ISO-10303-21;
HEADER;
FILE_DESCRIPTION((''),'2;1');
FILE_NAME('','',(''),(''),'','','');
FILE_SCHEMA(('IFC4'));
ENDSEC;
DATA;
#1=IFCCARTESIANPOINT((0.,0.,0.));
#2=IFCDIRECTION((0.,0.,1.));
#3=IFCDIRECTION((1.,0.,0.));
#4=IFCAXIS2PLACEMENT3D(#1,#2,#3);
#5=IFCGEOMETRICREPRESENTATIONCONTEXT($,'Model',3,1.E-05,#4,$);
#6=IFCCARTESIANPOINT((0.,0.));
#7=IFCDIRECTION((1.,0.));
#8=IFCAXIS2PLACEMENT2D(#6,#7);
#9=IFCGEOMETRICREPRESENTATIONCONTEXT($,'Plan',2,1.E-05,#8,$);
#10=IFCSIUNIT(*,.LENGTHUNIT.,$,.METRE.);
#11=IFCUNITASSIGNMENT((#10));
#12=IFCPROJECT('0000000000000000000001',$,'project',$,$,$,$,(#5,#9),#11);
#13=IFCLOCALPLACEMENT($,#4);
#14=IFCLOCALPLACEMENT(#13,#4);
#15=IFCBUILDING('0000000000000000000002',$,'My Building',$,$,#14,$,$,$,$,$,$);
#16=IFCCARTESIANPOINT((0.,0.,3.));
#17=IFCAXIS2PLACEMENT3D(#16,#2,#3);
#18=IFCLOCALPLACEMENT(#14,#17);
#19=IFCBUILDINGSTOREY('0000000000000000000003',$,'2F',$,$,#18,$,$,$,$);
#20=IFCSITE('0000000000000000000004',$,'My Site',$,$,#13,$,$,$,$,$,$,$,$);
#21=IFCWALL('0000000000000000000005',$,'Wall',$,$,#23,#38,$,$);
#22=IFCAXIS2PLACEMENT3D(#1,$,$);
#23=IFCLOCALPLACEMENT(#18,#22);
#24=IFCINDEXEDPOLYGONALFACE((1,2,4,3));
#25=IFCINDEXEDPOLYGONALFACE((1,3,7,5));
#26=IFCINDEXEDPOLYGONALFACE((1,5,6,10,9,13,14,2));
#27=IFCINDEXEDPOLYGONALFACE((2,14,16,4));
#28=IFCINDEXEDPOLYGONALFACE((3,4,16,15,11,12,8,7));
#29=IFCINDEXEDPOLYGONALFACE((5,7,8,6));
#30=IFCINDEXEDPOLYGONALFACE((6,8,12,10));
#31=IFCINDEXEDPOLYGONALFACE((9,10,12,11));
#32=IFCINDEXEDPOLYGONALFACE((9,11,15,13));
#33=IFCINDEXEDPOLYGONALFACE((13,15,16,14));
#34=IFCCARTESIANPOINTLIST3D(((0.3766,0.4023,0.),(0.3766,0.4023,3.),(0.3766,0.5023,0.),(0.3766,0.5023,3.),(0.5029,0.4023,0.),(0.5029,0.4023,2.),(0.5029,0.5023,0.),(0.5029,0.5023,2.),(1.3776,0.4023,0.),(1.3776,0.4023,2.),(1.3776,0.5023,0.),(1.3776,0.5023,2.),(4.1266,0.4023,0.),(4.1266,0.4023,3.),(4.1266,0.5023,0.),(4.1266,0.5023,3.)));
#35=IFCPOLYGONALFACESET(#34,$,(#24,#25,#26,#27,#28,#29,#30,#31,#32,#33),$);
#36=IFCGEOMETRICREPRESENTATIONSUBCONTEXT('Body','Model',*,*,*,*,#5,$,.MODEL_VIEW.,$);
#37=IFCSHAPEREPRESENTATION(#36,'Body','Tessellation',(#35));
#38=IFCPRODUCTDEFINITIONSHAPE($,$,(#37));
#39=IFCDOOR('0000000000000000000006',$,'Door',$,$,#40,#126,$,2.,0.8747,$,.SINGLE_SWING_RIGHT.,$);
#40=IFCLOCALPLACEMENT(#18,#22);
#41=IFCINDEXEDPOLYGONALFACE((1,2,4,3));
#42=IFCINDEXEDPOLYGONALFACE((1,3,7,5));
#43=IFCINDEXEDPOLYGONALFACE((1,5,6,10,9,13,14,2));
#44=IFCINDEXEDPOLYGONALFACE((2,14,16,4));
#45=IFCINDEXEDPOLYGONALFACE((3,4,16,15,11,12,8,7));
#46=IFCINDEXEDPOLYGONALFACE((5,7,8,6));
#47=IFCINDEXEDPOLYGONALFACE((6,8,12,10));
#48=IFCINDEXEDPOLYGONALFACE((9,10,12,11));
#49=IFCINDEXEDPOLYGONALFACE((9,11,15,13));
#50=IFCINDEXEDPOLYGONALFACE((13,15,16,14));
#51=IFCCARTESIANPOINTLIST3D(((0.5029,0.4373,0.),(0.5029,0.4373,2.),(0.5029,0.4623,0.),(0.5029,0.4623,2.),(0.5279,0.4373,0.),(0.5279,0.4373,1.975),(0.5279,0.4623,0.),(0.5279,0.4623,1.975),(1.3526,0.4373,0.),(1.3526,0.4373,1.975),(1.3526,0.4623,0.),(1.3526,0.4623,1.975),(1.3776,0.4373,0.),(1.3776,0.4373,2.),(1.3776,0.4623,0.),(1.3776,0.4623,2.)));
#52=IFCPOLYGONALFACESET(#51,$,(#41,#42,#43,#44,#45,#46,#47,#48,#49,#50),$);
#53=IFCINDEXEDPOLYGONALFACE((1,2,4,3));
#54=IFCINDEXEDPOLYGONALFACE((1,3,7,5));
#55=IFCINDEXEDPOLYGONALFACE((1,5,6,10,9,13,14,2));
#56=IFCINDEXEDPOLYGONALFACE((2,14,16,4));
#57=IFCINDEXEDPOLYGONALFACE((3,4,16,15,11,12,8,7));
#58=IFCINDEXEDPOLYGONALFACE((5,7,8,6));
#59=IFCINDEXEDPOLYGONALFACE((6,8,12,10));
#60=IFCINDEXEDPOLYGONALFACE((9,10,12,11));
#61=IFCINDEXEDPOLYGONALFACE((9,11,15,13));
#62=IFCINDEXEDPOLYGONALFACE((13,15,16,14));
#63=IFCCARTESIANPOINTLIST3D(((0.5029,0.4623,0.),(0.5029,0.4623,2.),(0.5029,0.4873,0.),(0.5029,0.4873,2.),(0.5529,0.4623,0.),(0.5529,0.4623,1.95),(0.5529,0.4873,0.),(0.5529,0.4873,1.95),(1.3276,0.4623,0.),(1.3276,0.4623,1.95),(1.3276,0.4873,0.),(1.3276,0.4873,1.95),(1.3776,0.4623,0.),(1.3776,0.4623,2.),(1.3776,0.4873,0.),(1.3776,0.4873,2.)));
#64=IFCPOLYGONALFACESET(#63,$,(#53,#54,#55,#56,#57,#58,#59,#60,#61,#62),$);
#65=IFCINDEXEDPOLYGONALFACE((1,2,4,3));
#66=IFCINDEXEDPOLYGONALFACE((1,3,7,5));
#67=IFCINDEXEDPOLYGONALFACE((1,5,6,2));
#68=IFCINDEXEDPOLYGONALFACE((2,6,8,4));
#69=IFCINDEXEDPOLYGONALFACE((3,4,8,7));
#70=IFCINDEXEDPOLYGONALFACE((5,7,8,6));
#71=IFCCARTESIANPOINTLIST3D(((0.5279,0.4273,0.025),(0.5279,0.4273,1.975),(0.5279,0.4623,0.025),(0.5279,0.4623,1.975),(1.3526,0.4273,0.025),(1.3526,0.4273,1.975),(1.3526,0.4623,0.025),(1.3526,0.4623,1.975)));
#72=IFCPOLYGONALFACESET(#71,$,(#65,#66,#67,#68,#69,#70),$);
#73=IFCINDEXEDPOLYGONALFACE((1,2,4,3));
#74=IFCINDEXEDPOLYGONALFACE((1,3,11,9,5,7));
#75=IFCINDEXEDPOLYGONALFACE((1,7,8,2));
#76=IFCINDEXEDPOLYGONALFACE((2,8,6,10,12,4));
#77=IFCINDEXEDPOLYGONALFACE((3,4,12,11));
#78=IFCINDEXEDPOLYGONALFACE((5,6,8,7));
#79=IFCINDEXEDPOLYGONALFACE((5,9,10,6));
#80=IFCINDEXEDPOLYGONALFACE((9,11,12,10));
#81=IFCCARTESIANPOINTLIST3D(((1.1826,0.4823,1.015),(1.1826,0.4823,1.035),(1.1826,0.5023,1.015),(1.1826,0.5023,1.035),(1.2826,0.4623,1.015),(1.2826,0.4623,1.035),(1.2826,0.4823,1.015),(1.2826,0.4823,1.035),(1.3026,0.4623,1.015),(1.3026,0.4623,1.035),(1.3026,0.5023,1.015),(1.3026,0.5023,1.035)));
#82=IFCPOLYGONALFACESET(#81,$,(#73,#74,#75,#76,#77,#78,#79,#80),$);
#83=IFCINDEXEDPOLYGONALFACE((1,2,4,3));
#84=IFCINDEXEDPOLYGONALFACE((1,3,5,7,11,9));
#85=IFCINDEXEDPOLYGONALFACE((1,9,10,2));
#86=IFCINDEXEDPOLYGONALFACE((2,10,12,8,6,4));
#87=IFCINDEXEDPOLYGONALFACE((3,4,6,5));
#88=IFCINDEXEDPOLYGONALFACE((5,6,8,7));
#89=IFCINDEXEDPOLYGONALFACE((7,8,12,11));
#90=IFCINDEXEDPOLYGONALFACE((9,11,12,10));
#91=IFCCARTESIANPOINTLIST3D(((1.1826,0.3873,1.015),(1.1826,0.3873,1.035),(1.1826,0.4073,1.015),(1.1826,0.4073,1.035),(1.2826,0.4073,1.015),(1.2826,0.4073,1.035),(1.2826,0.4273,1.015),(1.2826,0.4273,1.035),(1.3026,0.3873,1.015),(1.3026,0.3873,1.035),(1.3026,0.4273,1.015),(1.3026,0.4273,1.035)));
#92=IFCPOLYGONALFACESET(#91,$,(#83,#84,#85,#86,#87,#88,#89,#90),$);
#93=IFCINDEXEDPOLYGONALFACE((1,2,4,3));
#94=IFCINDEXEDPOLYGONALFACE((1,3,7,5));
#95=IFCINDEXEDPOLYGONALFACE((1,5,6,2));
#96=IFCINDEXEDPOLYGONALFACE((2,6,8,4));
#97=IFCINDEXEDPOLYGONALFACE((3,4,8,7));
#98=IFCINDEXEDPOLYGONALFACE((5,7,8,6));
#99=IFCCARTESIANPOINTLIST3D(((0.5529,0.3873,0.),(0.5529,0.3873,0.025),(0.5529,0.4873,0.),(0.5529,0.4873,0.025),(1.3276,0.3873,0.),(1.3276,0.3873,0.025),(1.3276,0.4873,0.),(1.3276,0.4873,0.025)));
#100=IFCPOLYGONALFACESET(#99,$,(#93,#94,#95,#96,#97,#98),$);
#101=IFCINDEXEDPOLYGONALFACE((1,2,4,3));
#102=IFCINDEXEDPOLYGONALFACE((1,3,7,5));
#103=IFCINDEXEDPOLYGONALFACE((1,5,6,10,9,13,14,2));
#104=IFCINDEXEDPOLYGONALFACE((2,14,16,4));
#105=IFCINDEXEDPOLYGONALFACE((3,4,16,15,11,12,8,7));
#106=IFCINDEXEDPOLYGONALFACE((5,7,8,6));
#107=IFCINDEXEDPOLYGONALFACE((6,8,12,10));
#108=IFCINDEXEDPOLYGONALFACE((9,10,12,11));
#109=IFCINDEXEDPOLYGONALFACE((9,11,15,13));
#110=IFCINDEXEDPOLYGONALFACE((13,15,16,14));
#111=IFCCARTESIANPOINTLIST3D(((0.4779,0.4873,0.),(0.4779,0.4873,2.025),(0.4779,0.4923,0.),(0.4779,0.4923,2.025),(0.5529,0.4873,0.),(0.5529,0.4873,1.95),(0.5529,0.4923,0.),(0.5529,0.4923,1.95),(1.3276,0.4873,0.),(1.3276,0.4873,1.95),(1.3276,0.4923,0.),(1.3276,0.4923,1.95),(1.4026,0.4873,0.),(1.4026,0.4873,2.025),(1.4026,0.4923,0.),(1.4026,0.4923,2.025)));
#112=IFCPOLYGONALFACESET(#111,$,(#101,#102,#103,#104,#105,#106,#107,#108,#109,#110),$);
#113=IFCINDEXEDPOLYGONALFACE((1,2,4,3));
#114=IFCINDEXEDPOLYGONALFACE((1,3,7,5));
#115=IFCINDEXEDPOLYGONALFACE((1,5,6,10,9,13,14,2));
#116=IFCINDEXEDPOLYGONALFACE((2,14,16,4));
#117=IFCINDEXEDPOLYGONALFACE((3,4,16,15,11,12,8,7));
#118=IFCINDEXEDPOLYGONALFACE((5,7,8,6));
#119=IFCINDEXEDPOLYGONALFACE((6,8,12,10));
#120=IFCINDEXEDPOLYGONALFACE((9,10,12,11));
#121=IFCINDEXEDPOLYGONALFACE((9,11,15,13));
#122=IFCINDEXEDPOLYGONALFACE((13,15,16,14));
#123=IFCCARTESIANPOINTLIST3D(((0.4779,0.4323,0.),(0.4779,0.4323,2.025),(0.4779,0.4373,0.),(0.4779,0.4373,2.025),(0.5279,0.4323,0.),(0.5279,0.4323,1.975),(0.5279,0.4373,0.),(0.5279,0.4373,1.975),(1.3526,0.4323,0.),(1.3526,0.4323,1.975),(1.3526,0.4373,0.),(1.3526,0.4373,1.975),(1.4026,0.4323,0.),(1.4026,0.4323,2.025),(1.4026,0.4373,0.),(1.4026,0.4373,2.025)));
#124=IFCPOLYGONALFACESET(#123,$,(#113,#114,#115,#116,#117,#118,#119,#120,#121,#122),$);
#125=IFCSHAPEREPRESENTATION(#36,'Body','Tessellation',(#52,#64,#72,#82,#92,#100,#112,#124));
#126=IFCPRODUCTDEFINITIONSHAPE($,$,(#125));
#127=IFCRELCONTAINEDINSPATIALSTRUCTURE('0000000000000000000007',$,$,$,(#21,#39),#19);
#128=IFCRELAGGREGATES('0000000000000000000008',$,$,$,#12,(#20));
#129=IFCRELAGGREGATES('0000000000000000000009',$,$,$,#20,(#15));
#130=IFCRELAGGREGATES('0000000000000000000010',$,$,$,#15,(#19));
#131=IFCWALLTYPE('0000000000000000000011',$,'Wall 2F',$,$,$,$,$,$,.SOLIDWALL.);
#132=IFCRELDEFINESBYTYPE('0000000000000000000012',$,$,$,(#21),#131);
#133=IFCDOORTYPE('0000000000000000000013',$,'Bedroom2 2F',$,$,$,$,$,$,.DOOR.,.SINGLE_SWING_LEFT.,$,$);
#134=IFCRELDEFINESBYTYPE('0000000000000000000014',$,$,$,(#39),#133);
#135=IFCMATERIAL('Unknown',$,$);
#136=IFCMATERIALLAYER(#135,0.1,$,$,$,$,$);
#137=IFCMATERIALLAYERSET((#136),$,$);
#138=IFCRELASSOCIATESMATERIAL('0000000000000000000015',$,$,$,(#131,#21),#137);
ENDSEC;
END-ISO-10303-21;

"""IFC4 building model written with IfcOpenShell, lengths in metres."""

from ifc_helpers import new_model, entity, si_unit, frame, origin_with_axes, origin_2d_with_axis, place, context, subcontext, project, spatial, line, indexed_curve, outline, extrude, shape, source, transform, mapped, material, layer, layer_set, layer_usage, type_object, type_shapes, element, fill, save


model = new_model("IFC4")

# Units and contexts
model_context = context("Model", 3, precision=1e-05, world=origin_with_axes())
plan_context = context("Plan", 2, precision=1e-05, world=origin_2d_with_axis())
body_context_1 = subcontext(model_context, "Body", "Model", "MODEL_VIEW")
body_context_2 = subcontext(plan_context, "Body", "Plan", "PLAN_VIEW")
ifc_project = project(units=[si_unit("LENGTHUNIT", "METRE")], contexts=[model_context, plan_context])

# Site, building, storey
site_placement = place(None, origin_with_axes())
site = spatial("IfcSite", under=ifc_project, at=site_placement, Name="My Site")
building_placement = place(site_placement, origin_with_axes())
building = spatial("IfcBuilding", under=site, at=building_placement, Name="My Building")
storey_placement = place(building_placement, frame((0.0, 0.0, 3.0), z_axis=(0.0, 0.0, 1.0), x_axis=(1.0, 0.0, 0.0)))
storey = spatial("IfcBuildingStorey", under=building, at=storey_placement, Name="2F")

# Shared definitions
ifc_material = material(Name="Unknown")

# Shared definitions
ifc_layer = layer(ifc_material, 0.1)
ifc_layer_set = layer_set([ifc_layer])
wall_type = type_object("IfcWallType", Name="Wall 2F", PredefinedType="SOLIDWALL", material=ifc_layer_set)

# Wall, opening, door
ifc_layer_usage_1 = layer_usage(ifc_layer_set, "AXIS2", "POSITIVE", 0.0)
wall_1_placement = place(storey_placement, frame((4.2266, 0.5023, 0.0), z_axis=(0.0, 0.0, 1.0), x_axis=(-1.0, 0.0, 0.0)))
wall_1 = element("IfcWall", 1, at=wall_1_placement, inside=storey, type_object=wall_type, material=ifc_layer_usage_1, Name="Wall", context=body_context_1, shape_type="SweptSolid", body=[
    extrude(outline(indexed_curve([(0.1, 0.0), (0.1, 0.1), (3.85, 0.1), (3.85, 0.0)], segments=[line(1, 2, 3, 4, 1)])), origin_with_axes(), (0.0, 0.0, 1.0), 3.0),
])
shared_shape_1 = source(origin_with_axes(), body_context_1, "Body", "SweptSolid", [
    extrude(outline(indexed_curve([(0.0, 0.0), (0.8747, 0.0), (0.8747, 2.0), (0.0, 2.0)], segments=[line(1, 2, 3, 4, 1)])), frame((0.0, -0.6, 0.0), z_axis=(0.0, -1.0, 0.0), x_axis=(1.0, 0.0, 0.0)), (0.0, 0.0, -1.0), 1.2),
])
opening_1_placement = place(wall_1_placement, frame((2.849, 0.015, 0.0), z_axis=(0.0, 0.0, 1.0), x_axis=(1.0, -0.000001, 0.0)))
opening_1 = element("IfcOpeningElement", 2, at=opening_1_placement, cuts=wall_1, PredefinedType="OPENING", context=body_context_1, shape_type="MappedRepresentation", body=[
    mapped(shared_shape_1, transform((0.0, 0.0, 0.0), x_axis=(1.0, 0.0, 0.0), y_axis=(0.0, 1.0, 0.0), z_axis=(0.0, 0.0, 1.0), scale=1.0)),
])
door_type_1 = type_object("IfcDoorType", Name="Bedroom2 2F", OperationType="SINGLE_SWING_LEFT", PredefinedType="DOOR")
shared_shape_2 = source(origin_with_axes(), body_context_1, "Body", "SweptSolid", [
    extrude(outline(indexed_curve([(0.0, 0.0), (0.0, 2.0), (0.8747, 2.0), (0.8747, 0.0), (0.8497, 0.0), (0.8497, 1.975), (0.025, 1.975), (0.025, 0.0)], segments=[line(1, 2, 3, 4, 5, 6, 7, 8, 1)])), frame((0.0, 0.025, 0.0), z_axis=(0.0, -1.0, 0.0), x_axis=(1.0, 0.0, 0.0)), (0.0, 0.0, -1.0), 0.025),
    extrude(outline(indexed_curve([(0.0, 0.0), (0.0, 2.0), (0.8747, 2.0), (0.8747, 0.0), (0.8247, 0.0), (0.8247, 1.95), (0.05, 1.95), (0.05, 0.0)], segments=[line(1, 2, 3, 4, 5, 6, 7, 8, 1)])), frame((0.0, 0.0, 0.0), z_axis=(0.0, -1.0, 0.0), x_axis=(1.0, 0.0, 0.0)), (0.0, 0.0, -1.0), 0.025),
    extrude(outline(indexed_curve([(0.0, 0.0), (0.8247, 0.0), (0.8247, 0.035), (0.0, 0.035)], segments=[line(1, 2, 3, 4, 1)])), frame((0.025, 0.025, 0.025), z_axis=(0.0, 0.0, 1.0), x_axis=(1.0, 0.0, 0.0)), (0.0, 0.0, 1.0), 1.95),
    extrude(outline(indexed_curve([(0.0, 0.0), (0.0, -0.04), (0.12, -0.04), (0.12, -0.02), (0.02, -0.02), (0.02, 0.0)], segments=[line(1, 2, 3, 4, 5, 6, 1)])), frame((0.075, 0.025, 1.015), z_axis=(0.0, 0.0, 1.0), x_axis=(1.0, 0.0, 0.0)), (0.0, 0.0, 1.0), 0.02),
    extrude(outline(indexed_curve([(0.0, 0.0), (0.0, 0.04), (0.12, 0.04), (0.12, 0.02), (0.02, 0.02), (0.02, 0.0)], segments=[line(1, 2, 3, 4, 5, 6, 1)])), frame((0.075, 0.06, 1.015), z_axis=(0.0, 0.0, 1.0), x_axis=(1.0, 0.0, 0.0)), (0.0, 0.0, 1.0), 0.02),
    extrude(outline(indexed_curve([(0.0, 0.0), (0.7747, 0.0), (0.7747, 0.1), (0.0, 0.1)], segments=[line(1, 2, 3, 4, 1)])), frame((0.05, 0.0, 0.0), z_axis=(0.0, 0.0, 1.0), x_axis=(1.0, 0.0, 0.0)), (0.0, 0.0, 1.0), 0.025),
    extrude(outline(indexed_curve([(0.0, 0.0), (0.0, 2.025), (0.9247, 2.025), (0.9247, 0.0), (0.8497, 0.0), (0.8497, 1.95), (0.075, 1.95), (0.075, 0.0)], segments=[line(1, 2, 3, 4, 5, 6, 7, 8, 1)])), frame((-0.025, -0.005, 0.0), z_axis=(0.0, -1.0, 0.0), x_axis=(1.0, 0.0, 0.0)), (0.0, 0.0, -1.0), 0.005),
    extrude(outline(indexed_curve([(0.0, 0.0), (0.0, 2.025), (0.9247, 2.025), (0.9247, 0.0), (0.8747, 0.0), (0.8747, 1.975), (0.05, 1.975), (0.05, 0.0)], segments=[line(1, 2, 3, 4, 5, 6, 7, 8, 1)])), frame((-0.025, 0.05, 0.0), z_axis=(0.0, -1.0, 0.0), x_axis=(1.0, 0.0, 0.0)), (0.0, 0.0, -1.0), 0.005),
])
shared_shape_3 = source(origin_with_axes(), body_context_2, "Body", "Curve2D", [
    entity("IfcIndexedPolyCurve", entity("IfcCartesianPointList2D", [[0.0, 0.0], [0.0, 0.05], [0.025, 0.05], [0.025, 0.025], [0.05, 0.025], [0.05, 0.0]]), [entity("IfcLineIndex", [1, 2, 3, 4, 5, 6, 1])]),
    entity("IfcIndexedPolyCurve", entity("IfcCartesianPointList2D", [[0.8747, 0.0], [0.8747, 0.05], [0.8497, 0.05], [0.8497, 0.025], [0.8247, 0.025], [0.8247, 0.0]]), [entity("IfcLineIndex", [1, 2, 3, 4, 5, 6, 1])]),
    entity("IfcTrimmedCurve", entity("IfcEllipse", entity("IfcAxis2Placement2D", entity("IfcCartesianPoint", [0.8147, 0.05]), entity("IfcDirection", [1.0, 0.0])), 0.7897, 0.8247), [entity("IfcCartesianPoint", [0.8147, 0.8747])], [entity("IfcCartesianPoint", [0.025, 0.05])], True, "CARTESIAN"),
    entity("IfcIndexedPolyCurve", entity("IfcCartesianPointList2D", [[0.8497, 0.05], [0.8147, 0.05], [0.8147, 0.8747], [0.8497, 0.8747]]), [entity("IfcLineIndex", [1, 2, 3, 4, 1])]),
])
type_shapes(door_type_1, [shared_shape_2, shared_shape_3])
door_1_placement = place(opening_1_placement, frame((0.0, 0.0, 0.0), z_axis=(0.0, 0.0, 1.0), x_axis=(1.0, 0.0, 0.0)))
door_1 = element("IfcDoor", 3, at=door_1_placement, inside=storey, type_object=door_type_1, Name="Door", OperationType="SINGLE_SWING_RIGHT", OverallHeight=2.0, OverallWidth=0.8747, shapes=[
    shape(body_context_1, "Body", "MappedRepresentation", [mapped(shared_shape_2, transform((0.0, 0.0, 0.0), x_axis=(1.0, 0.0, 0.0), y_axis=(0.0, 1.0, 0.0), z_axis=(0.0, 0.0, 1.0), scale=1.0))]),
    shape(body_context_2, "Body", "MappedRepresentation", [mapped(shared_shape_3, transform((0.0, 0.0, 0.0), x_axis=(1.0, 0.0, 0.0), y_axis=(0.0, 1.0, 0.0), z_axis=(0.0, 0.0, 1.0), scale=1.0))]),
])
fill(opening_1, door_1)

save(model, "model.ifc")
